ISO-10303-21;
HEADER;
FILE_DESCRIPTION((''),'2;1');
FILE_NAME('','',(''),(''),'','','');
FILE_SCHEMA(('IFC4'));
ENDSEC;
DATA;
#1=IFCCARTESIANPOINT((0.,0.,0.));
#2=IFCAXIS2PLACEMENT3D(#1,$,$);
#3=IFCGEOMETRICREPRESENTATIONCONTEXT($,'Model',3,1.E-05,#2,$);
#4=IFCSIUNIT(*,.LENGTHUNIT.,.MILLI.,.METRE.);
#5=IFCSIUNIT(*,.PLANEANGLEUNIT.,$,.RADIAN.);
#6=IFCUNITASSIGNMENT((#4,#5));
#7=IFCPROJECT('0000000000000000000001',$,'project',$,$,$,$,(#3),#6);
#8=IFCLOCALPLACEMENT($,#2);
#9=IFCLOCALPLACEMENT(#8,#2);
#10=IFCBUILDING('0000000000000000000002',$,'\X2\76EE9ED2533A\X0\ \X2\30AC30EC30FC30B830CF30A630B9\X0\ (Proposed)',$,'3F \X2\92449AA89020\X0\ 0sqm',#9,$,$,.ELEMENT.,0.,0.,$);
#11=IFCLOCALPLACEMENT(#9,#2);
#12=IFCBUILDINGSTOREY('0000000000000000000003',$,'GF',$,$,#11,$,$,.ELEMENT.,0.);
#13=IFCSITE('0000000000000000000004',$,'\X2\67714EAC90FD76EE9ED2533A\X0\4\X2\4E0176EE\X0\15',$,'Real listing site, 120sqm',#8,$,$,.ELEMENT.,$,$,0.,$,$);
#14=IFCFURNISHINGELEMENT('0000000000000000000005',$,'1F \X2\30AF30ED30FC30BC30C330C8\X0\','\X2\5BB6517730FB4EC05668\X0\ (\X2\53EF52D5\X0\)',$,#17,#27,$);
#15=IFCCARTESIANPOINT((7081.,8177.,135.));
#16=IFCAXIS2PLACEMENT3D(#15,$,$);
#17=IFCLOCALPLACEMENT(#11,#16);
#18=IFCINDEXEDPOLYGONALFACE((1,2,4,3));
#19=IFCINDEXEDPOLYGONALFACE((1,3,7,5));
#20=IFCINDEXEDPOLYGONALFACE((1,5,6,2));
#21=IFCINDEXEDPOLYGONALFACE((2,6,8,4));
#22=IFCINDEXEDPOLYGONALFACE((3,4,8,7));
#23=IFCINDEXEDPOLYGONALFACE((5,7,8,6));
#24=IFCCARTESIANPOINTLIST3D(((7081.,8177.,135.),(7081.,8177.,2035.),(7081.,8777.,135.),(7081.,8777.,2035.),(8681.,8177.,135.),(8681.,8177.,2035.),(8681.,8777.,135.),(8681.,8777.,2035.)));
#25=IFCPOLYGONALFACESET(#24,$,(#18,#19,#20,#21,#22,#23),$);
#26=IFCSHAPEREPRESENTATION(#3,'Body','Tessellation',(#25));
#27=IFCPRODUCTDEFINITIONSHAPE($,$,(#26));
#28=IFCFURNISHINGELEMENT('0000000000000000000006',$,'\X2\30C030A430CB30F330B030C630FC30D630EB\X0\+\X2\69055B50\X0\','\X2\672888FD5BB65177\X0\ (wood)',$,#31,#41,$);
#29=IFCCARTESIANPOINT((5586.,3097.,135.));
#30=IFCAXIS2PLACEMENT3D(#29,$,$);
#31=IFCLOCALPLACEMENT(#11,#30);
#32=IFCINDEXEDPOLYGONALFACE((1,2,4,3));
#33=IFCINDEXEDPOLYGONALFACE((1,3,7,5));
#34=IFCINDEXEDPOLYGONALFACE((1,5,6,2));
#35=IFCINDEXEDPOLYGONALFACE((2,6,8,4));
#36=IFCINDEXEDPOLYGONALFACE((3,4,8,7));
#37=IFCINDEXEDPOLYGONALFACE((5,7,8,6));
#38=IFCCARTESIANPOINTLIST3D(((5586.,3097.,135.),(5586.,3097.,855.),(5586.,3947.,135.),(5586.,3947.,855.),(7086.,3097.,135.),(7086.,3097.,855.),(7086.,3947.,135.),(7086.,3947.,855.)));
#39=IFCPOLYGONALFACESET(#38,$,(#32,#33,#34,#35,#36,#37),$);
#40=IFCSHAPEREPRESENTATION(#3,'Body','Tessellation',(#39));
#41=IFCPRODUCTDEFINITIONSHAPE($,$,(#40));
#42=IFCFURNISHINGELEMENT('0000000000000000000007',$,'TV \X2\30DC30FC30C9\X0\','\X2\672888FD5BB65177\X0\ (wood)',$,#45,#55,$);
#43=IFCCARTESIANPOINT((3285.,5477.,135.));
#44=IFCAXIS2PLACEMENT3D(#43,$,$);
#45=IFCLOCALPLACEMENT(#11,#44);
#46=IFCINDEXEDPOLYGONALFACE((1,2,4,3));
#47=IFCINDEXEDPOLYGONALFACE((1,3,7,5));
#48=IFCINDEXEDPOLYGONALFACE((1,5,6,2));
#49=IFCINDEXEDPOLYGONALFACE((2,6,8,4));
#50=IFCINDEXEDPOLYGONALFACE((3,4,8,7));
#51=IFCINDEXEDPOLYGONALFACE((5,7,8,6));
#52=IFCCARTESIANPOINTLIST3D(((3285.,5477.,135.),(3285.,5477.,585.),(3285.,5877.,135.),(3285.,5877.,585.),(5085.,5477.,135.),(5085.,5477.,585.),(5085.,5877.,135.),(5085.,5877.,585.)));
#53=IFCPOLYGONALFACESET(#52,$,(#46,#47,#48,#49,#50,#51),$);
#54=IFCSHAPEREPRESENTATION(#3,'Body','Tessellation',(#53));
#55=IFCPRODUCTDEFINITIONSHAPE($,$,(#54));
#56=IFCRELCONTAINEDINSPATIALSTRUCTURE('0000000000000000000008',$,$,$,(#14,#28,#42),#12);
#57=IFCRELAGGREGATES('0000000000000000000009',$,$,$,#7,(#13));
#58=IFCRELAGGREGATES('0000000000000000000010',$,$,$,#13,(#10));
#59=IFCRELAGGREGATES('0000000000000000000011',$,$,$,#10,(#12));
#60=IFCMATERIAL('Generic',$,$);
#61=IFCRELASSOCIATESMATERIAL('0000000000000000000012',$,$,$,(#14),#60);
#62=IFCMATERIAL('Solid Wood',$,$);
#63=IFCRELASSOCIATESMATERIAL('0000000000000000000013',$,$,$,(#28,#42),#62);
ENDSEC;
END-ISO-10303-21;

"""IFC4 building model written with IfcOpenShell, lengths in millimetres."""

from ifc_helpers import new_model, si_unit, frame, frame_2d, origin, place, context, project, spatial, rectangle, extrude, material, element, save


model = new_model("IFC4")

# Units and contexts
model_context = context("Model", 3, precision=1e-05, world=origin())
ifc_project = project(units=[si_unit("LENGTHUNIT", "METRE", prefix="MILLI"), si_unit("PLANEANGLEUNIT", "RADIAN")], contexts=[model_context])

# Site, building, storey
site_placement = place(None, origin())
site = spatial("IfcSite", under=ifc_project, at=site_placement, Name="東京都目黒区4丁目15", ObjectType="Real listing site, 120sqm", CompositionType="ELEMENT", RefElevation=0.0)
building_placement = place(site_placement, origin())
building = spatial("IfcBuilding", under=site, at=building_placement, Name="目黒区 ガレージハウス (Proposed)", ObjectType="3F 鉄骨造 0sqm", CompositionType="ELEMENT", ElevationOfRefHeight=0.0, ElevationOfTerrain=0.0)
storey_placement = place(building_placement, origin())
storey = spatial("IfcBuildingStorey", under=building, at=storey_placement, Name="GF", CompositionType="ELEMENT", Elevation=0.0)

# Shared definitions
ifc_material_1 = material(Name="Solid Wood")

# Shared definitions
ifc_material_2 = material(Name="Generic")

# Furnishing elements
furnishing_1_placement = place(storey_placement, frame((7081.0, 8177.0, 135.0)))
element("IfcFurnishingElement", 1, at=furnishing_1_placement, inside=storey, material=ifc_material_2, Name="1F クローゼット", Description="家具・什器 (可動)", context=model_context, shape_type="SweptSolid", body=[
    extrude(rectangle(XDim=1600.0, YDim=600.0, at=frame_2d((800.0, 300.0))), frame((7081.0, 8177.0, 135.0)), (0.0, 0.0, 1.0), 1900.0),
])
furnishing_2_placement = place(storey_placement, frame((5586.0, 3097.0, 135.0)))
element("IfcFurnishingElement", 2, at=furnishing_2_placement, inside=storey, material=ifc_material_1, Name="ダイニングテーブル+椅子", Description="木製家具 (wood)", context=model_context, shape_type="SweptSolid", body=[
    extrude(rectangle(XDim=1500.0, YDim=850.0, at=frame_2d((750.0, 425.0))), frame((5586.0, 3097.0, 135.0)), (0.0, 0.0, 1.0), 720.0),
])
furnishing_3_placement = place(storey_placement, frame((3285.0, 5477.0, 135.0)))
element("IfcFurnishingElement", 3, at=furnishing_3_placement, inside=storey, material=ifc_material_1, Name="TV ボード", Description="木製家具 (wood)", context=model_context, shape_type="SweptSolid", body=[
    extrude(rectangle(XDim=1800.0, YDim=400.0, at=frame_2d((900.0, 200.0))), frame((3285.0, 5477.0, 135.0)), (0.0, 0.0, 1.0), 450.0),
])

save(model, "model.ifc")
